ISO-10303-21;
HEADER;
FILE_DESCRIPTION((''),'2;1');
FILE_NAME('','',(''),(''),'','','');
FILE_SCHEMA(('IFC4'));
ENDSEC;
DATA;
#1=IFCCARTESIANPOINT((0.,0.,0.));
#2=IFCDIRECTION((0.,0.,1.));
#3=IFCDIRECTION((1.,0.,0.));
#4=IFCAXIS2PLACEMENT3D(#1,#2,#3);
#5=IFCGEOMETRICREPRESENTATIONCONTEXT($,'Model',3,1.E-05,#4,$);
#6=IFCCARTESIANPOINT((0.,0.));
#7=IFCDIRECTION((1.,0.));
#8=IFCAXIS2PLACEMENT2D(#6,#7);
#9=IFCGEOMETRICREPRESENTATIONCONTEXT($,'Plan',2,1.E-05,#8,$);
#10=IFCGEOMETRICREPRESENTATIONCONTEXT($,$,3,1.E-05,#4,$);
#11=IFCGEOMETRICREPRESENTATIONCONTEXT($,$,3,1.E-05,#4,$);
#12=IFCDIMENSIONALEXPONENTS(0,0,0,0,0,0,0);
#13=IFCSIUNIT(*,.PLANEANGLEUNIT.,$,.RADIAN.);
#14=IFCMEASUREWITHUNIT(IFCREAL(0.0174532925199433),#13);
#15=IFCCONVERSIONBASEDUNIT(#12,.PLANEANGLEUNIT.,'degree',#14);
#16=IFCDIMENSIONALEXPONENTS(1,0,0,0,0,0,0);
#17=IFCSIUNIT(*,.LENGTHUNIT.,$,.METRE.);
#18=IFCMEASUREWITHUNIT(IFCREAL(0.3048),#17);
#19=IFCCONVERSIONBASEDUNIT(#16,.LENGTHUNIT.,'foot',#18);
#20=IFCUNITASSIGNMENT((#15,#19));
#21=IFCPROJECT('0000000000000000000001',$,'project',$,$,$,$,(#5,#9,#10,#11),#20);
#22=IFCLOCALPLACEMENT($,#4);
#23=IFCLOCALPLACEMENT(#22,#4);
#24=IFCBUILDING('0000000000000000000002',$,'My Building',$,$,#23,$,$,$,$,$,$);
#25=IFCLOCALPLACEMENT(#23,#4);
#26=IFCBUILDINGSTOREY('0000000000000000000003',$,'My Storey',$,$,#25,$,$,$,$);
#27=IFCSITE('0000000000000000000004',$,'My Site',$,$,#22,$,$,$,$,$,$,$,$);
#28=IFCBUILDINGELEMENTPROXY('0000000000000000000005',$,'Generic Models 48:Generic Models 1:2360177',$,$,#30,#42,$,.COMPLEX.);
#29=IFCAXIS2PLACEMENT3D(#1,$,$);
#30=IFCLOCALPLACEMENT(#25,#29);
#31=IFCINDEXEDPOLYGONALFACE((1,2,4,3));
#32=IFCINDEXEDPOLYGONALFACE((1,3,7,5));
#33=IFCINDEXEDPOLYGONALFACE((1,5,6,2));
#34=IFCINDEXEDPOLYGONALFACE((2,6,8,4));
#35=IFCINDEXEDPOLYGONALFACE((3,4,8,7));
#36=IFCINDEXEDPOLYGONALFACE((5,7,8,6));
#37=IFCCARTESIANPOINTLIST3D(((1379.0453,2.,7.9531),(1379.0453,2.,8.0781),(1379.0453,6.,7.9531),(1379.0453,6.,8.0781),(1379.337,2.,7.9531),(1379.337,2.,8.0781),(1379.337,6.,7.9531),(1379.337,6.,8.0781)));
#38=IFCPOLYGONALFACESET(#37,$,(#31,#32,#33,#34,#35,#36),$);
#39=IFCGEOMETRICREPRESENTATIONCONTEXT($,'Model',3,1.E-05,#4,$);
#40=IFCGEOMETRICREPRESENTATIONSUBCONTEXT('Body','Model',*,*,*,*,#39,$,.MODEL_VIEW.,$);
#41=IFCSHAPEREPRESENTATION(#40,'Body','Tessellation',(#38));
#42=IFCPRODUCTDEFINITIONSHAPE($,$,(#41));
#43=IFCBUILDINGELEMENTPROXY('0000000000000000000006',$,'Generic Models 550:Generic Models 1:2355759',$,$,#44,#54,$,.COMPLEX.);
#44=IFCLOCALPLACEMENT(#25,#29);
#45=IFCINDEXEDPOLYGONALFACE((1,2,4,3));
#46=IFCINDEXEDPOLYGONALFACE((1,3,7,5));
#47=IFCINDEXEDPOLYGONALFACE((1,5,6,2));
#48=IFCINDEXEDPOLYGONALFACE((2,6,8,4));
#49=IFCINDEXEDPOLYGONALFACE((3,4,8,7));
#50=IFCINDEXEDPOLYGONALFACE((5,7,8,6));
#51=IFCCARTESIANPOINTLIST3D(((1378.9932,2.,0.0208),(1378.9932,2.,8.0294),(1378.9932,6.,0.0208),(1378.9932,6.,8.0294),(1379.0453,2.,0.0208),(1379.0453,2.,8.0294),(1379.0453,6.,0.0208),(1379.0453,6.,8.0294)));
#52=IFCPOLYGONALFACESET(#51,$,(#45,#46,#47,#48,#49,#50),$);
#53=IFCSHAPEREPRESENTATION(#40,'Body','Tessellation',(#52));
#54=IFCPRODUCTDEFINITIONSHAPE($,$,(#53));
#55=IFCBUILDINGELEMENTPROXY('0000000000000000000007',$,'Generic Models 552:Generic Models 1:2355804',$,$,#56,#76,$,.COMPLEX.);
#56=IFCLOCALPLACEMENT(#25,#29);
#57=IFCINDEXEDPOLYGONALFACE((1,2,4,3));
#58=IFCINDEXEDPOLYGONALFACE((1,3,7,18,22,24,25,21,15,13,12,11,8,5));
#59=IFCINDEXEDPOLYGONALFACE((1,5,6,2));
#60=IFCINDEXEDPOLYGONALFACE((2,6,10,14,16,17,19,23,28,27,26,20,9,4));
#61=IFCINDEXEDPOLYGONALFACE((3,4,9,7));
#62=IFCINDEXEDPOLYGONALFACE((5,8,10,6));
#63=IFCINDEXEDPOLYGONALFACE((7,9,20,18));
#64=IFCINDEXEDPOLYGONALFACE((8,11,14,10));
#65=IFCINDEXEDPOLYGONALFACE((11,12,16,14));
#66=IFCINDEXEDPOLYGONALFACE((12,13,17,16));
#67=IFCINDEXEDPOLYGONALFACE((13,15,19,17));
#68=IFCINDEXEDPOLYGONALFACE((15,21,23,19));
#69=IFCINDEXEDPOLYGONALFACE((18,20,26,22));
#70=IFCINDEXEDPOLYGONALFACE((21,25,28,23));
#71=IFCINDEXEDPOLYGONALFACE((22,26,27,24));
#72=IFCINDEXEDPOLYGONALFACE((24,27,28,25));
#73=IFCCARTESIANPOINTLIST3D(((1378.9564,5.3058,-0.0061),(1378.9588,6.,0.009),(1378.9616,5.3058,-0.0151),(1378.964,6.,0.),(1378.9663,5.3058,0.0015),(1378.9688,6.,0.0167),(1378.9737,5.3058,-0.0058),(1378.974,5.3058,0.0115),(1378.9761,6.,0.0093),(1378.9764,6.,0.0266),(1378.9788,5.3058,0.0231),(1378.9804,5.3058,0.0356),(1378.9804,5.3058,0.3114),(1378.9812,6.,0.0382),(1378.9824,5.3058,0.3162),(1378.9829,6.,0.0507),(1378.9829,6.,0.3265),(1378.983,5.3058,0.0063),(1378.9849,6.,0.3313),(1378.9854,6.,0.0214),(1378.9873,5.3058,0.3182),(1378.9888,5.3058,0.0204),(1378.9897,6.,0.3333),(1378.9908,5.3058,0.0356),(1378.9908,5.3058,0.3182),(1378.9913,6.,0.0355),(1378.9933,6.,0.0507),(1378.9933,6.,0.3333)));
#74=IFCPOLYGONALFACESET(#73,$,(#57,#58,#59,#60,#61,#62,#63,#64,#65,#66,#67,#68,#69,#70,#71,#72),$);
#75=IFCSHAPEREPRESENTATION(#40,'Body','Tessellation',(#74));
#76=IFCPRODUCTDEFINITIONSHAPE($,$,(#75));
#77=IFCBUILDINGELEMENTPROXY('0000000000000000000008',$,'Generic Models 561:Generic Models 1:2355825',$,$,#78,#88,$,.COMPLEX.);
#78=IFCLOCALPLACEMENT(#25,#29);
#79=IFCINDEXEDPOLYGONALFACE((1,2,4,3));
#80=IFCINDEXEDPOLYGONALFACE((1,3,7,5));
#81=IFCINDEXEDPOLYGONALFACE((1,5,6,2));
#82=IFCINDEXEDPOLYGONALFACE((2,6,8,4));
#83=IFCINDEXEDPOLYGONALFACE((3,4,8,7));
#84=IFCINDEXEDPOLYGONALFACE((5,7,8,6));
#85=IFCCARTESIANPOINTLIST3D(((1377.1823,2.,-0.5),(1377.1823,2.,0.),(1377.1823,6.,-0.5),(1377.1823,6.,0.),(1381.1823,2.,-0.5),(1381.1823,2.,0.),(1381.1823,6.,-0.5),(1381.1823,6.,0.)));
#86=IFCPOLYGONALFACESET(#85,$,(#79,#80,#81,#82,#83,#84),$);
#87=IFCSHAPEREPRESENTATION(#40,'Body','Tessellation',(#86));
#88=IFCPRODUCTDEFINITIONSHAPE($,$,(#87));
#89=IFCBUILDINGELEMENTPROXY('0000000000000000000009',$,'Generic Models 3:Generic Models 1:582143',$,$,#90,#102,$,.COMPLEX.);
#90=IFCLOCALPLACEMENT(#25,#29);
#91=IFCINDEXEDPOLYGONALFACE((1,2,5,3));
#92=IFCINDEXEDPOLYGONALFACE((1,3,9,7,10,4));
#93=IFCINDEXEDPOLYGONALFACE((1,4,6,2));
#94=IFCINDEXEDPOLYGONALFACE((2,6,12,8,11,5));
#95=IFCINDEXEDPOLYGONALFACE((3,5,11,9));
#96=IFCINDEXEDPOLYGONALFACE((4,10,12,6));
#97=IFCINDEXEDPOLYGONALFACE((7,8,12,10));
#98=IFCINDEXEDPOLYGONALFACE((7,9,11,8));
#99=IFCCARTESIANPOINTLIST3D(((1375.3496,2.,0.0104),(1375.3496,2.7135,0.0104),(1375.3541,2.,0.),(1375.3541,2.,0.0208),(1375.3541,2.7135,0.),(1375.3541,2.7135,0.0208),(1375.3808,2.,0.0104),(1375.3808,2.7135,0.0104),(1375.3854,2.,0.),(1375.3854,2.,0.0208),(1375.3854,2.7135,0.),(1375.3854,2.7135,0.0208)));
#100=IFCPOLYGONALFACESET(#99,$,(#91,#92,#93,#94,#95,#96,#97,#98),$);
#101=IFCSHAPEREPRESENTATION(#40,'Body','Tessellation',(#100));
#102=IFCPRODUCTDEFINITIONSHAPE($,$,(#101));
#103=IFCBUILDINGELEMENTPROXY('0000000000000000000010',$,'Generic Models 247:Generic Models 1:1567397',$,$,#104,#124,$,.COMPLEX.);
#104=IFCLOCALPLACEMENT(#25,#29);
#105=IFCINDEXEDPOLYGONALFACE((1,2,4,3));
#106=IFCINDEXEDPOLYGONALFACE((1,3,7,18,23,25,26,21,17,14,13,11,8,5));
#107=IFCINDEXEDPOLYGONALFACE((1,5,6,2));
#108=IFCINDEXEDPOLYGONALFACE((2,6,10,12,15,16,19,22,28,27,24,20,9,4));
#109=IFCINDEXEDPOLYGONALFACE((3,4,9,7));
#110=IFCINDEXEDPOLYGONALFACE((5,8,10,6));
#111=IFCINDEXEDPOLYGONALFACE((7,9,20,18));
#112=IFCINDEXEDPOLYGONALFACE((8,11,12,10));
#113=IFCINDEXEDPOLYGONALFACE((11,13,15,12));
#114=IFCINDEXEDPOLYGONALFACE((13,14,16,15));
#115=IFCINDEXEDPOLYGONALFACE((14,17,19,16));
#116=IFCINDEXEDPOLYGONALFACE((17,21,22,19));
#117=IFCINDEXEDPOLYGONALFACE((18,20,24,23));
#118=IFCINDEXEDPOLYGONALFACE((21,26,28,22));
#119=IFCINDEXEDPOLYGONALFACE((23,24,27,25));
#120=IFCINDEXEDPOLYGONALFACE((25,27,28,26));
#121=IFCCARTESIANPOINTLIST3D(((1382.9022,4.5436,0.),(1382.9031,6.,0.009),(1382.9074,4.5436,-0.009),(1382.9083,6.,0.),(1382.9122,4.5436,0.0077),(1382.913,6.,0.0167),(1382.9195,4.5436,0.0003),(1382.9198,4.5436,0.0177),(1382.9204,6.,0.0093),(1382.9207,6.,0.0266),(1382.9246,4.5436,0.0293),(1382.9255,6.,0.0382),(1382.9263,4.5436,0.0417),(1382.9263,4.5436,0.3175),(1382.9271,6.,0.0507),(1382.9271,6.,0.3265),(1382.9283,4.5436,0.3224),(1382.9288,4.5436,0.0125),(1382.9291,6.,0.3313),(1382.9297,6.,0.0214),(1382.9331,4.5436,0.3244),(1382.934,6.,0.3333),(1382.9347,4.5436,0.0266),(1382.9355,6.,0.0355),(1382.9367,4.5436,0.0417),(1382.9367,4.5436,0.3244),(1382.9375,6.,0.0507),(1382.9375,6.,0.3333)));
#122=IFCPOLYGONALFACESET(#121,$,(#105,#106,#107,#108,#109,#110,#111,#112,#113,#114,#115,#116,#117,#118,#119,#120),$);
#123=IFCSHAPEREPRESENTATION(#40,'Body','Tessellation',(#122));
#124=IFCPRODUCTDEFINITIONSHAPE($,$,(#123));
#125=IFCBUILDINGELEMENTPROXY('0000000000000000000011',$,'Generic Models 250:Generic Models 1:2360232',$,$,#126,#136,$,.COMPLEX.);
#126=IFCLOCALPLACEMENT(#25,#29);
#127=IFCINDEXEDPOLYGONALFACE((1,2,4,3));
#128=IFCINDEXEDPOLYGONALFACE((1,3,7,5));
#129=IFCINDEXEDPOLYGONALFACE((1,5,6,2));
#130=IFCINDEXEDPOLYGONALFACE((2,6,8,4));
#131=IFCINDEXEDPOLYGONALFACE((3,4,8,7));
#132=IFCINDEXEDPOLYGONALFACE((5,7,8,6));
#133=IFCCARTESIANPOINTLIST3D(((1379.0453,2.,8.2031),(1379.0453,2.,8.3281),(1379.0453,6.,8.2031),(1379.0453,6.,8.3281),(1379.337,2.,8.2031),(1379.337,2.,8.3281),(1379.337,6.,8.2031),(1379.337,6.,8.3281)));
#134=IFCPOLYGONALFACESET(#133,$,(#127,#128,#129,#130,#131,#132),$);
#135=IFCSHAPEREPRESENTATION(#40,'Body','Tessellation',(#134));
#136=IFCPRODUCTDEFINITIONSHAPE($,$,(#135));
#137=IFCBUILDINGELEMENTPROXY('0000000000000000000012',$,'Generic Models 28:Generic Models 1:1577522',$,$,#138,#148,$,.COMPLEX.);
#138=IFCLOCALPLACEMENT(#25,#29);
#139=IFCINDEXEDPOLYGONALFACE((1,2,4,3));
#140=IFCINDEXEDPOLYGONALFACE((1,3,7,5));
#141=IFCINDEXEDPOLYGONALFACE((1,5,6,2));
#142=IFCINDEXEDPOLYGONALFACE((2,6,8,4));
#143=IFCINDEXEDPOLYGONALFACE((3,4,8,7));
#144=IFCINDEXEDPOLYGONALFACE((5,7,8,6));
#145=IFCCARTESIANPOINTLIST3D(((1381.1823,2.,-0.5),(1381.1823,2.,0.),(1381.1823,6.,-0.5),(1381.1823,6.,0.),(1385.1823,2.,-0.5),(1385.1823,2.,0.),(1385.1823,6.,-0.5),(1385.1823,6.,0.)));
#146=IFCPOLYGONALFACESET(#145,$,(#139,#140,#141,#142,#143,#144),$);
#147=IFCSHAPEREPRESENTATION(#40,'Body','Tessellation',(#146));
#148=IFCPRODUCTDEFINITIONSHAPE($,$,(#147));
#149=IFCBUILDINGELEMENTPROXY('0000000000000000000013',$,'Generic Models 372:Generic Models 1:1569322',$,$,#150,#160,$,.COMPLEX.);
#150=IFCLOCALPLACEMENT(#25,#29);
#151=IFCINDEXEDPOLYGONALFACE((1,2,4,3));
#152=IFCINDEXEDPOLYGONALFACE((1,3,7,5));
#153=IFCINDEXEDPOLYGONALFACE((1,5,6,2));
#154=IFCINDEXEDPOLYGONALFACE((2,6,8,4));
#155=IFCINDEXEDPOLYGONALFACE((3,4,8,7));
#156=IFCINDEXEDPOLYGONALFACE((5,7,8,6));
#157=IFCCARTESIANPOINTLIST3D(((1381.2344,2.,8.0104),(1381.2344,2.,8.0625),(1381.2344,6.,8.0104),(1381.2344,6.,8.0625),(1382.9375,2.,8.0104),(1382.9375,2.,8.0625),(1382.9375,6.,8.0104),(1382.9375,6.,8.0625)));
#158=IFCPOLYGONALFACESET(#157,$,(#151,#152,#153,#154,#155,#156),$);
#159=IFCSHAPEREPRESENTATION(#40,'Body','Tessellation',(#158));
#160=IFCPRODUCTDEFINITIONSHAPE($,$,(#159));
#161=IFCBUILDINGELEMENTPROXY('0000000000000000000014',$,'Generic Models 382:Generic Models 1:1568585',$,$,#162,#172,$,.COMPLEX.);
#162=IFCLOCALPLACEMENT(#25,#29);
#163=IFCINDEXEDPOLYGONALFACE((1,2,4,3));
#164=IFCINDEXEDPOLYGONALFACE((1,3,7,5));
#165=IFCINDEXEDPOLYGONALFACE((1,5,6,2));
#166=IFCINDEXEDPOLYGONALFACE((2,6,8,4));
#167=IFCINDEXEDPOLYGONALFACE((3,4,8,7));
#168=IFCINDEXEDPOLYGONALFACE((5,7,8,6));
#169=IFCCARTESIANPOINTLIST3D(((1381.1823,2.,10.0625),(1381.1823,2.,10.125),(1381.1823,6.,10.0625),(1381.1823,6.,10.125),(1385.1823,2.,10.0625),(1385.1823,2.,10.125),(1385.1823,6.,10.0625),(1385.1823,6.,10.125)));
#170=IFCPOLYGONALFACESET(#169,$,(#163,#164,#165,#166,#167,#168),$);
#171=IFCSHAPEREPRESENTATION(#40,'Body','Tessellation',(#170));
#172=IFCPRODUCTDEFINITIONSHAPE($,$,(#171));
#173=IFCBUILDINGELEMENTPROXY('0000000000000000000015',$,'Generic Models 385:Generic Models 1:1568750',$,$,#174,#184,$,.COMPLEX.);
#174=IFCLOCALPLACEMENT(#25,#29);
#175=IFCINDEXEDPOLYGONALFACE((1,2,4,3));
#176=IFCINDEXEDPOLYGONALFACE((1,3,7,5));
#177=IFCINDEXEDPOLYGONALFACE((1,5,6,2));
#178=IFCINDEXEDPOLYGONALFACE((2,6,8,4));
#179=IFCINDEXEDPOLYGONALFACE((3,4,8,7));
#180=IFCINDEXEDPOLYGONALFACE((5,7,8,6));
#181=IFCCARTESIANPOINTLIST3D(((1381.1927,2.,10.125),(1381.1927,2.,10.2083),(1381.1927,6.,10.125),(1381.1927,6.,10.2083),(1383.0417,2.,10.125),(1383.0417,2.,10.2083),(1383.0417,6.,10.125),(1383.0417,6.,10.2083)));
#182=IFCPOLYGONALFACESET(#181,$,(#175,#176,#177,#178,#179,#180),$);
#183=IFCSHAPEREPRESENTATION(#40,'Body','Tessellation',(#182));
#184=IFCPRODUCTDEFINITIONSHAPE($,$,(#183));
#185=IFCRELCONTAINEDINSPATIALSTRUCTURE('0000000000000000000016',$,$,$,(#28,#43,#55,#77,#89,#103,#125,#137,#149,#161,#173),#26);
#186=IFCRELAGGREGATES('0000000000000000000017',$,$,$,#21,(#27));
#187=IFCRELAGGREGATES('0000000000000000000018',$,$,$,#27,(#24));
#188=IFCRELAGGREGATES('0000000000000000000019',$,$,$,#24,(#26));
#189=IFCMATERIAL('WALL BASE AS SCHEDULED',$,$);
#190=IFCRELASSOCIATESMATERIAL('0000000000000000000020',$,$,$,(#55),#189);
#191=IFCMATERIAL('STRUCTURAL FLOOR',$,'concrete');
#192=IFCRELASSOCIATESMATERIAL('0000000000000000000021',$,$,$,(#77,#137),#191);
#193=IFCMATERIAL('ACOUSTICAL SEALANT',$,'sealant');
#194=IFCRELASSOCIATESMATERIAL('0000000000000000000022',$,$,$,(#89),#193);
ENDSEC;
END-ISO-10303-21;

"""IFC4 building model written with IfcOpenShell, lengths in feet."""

from ifc_helpers import new_model, entity, si_unit, converted_unit, frame, origin_with_axes, origin_2d_with_axis, place, context, subcontext, project, spatial, polyline, outline, extrude, material, element, save


model = new_model("IFC4")

# Units and contexts
model_context_1 = context("Model", 3, precision=1e-05, world=origin_with_axes())
plan_context = context("Plan", 2, precision=1e-05, world=origin_2d_with_axis())
model_context_2 = context("Model", 3, precision=1e-05, world=origin_with_axes())
context_of_model_1 = context(None, 3, precision=1e-05, world=origin_with_axes())
context_of_model_2 = context(None, 3, precision=1e-05, world=origin_with_axes())
body_context = subcontext(model_context_2, "Body", "Model", "MODEL_VIEW")
ifc_project = project(units=[converted_unit("PLANEANGLEUNIT", "degree", entity("IfcReal", 0.0174532925199433), si_unit("PLANEANGLEUNIT", "RADIAN"), dimensions=[0, 0, 0, 0, 0, 0, 0]), converted_unit("LENGTHUNIT", "foot", entity("IfcReal", 0.3048), si_unit("LENGTHUNIT", "METRE"), dimensions=[1, 0, 0, 0, 0, 0, 0])], contexts=[model_context_1, plan_context, context_of_model_1, context_of_model_2])

# Site, building, storey
site_placement = place(None, origin_with_axes())
site = spatial("IfcSite", under=ifc_project, at=site_placement, Name="My Site")
building_placement = place(site_placement, origin_with_axes())
building = spatial("IfcBuilding", under=site, at=building_placement, Name="My Building")
storey_placement = place(building_placement, origin_with_axes())
storey = spatial("IfcBuildingStorey", under=building, at=storey_placement, Name="My Storey")

# Building element proxies
proxy_1_placement = place(storey_placement, frame((1379.0453, 6.0, 7.9531), z_axis=(0.0, -1.0, 0.0), x_axis=(0.0, 0.0, 1.0)))
element("IfcBuildingElementProxy", 1, at=proxy_1_placement, inside=storey, Name="Generic Models 48:Generic Models 1:2360177", PredefinedType="COMPLEX", context=body_context, shape_type="SweptSolid", body=[
    extrude(outline(polyline([(-0.1458, -0.0625), (0.1458, -0.0625), (0.1458, 0.0625), (-0.1458, 0.0625), (-0.1458, -0.0625)])), frame((0.0625, -0.1458, 0.0), z_axis=(0.0, 0.0, -1.0), x_axis=(0.0, 1.0, 0.0)), (0.0, 0.0, -1.0), 4.0),
])
proxy_2_placement = place(storey_placement, frame((1378.9932, 6.0, 0.0208), z_axis=(0.0, -1.0, 0.0), x_axis=(0.0, 0.0, 1.0)))
element("IfcBuildingElementProxy", 2, at=proxy_2_placement, inside=storey, Name="Generic Models 550:Generic Models 1:2355759", PredefinedType="COMPLEX", context=body_context, shape_type="SweptSolid", body=[
    extrude(outline(polyline([(-4.0043, -0.026), (4.0043, -0.026), (4.0043, 0.026), (-4.0043, 0.026), (-4.0043, -0.026)])), frame((4.0043, -0.026, 0.0), z_axis=(0.0, 0.0, -1.0), x_axis=(1.0, 0.0, 0.0)), (0.0, 0.0, -1.0), 4.0),
])
ifc_material_1 = material(Name="WALL BASE AS SCHEDULED")
proxy_3_placement = place(storey_placement, frame((1378.9588, 6.0, 0.0), z_axis=(0.0, -1.0, 0.0), x_axis=(0.0, 0.0, 1.0)))
element("IfcBuildingElementProxy", 3, at=proxy_3_placement, inside=storey, material=ifc_material_1, Name="Generic Models 552:Generic Models 1:2355804", PredefinedType="COMPLEX", context=body_context, shape_type="SweptSolid", body=[
    extrude(outline(polyline([(0.2205, 0.0), (0.2206, 0.0036), (-0.0618, 0.0152), (-0.077, 0.0138), (-0.0914, 0.0086), (-0.1038, -0.0002), (-0.1136, -0.012), (-0.1048, -0.0175), (-0.0968, -0.0079), (-0.0865, -0.0007), (-0.0747, 0.0037), (-0.0622, 0.0048), (0.2133, -0.0066), (0.2183, -0.0048), (0.2205, 0.0)])), frame((0.113, -0.0218, 0.0), z_axis=(0.0, 0.0, -1.0), x_axis=(0.999153, -0.041137, 0.0)), (-0.02192, -0.002617, -0.999756), 0.6943),
])
ifc_material_2 = material(Name="STRUCTURAL FLOOR", Category="concrete")
proxy_4_placement = place(storey_placement, frame((1377.1823, 6.0, -0.5), z_axis=(0.0, -1.0, 0.0), x_axis=(0.0, 0.0, 1.0)))
element("IfcBuildingElementProxy", 4, at=proxy_4_placement, inside=storey, material=ifc_material_2, Name="Generic Models 561:Generic Models 1:2355825", PredefinedType="COMPLEX", context=body_context, shape_type="SweptSolid", body=[
    extrude(outline(polyline([(-0.25, -2.0), (0.25, -2.0), (0.25, 2.0), (-0.25, 2.0), (-0.25, -2.0)])), frame((0.25, -2.0, 0.0), z_axis=(0.0, 0.0, -1.0), x_axis=(1.0, 0.0, 0.0)), (0.0, 0.0, -1.0), 4.0),
])
ifc_material_3 = material(Name="ACOUSTICAL SEALANT", Category="sealant")
proxy_5_placement = place(storey_placement, frame((1375.3497, 6.0, 0.0), z_axis=(0.0, -1.0, 0.0), x_axis=(0.0, 0.0, -1.0)))
element("IfcBuildingElementProxy", 5, at=proxy_5_placement, inside=storey, material=ifc_material_3, Name="Generic Models 3:Generic Models 1:582143", PredefinedType="COMPLEX", context=body_context, shape_type="SweptSolid", body=[
    extrude(outline(polyline([(0.0187, 0.0), (0.0141, 0.0104), (-0.0172, 0.0104), (-0.0126, 0.0), (-0.0172, -0.0104), (0.0141, -0.0104), (0.0187, 0.0)])), frame((-0.0104, 0.0186, 3.2865), z_axis=(0.0, 0.0, -1.0), x_axis=(0.0, -1.0, 0.0)), (0.0, 0.0, -1.0), 0.7135),
])
proxy_6_placement = place(storey_placement, frame((1382.9031, 6.0, 0.0), z_axis=(0.0, -1.0, 0.0), x_axis=(0.0, 0.0, 1.0)))
element("IfcBuildingElementProxy", 6, at=proxy_6_placement, inside=storey, Name="Generic Models 247:Generic Models 1:1567397", PredefinedType="COMPLEX", context=body_context, shape_type="SweptSolid", body=[
    extrude(outline(polyline([(-0.0624, 0.0022), (0.2134, 0.0022), (0.2183, 0.0042), (0.2203, 0.0091), (0.2203, 0.0126), (-0.0624, 0.0126), (-0.0775, 0.0106), (-0.0916, 0.0048), (-0.1037, -0.0045), (-0.113, -0.0166), (-0.104, -0.0218), (-0.0964, -0.0119), (-0.0864, -0.0042), (-0.0748, 0.0006), (-0.0624, 0.0022)])), frame((0.113, -0.0218, 0.0), z_axis=(0.0, 0.0, -1.0), x_axis=(1.0, 0.0, 0.0)), (-0.006161, -0.00058, -0.999981), 1.4564),
])
proxy_7_placement = place(storey_placement, frame((1379.0453, 6.0, 8.2031), z_axis=(0.0, -1.0, 0.0), x_axis=(0.0, 0.0, 1.0)))
element("IfcBuildingElementProxy", 7, at=proxy_7_placement, inside=storey, Name="Generic Models 250:Generic Models 1:2360232", PredefinedType="COMPLEX", context=body_context, shape_type="SweptSolid", body=[
    extrude(outline(polyline([(-0.0625, -0.1458), (0.0625, -0.1458), (0.0625, 0.1458), (-0.0625, 0.1458), (-0.0625, -0.1458)])), frame((0.0625, -0.1458, 0.0), z_axis=(0.0, 0.0, -1.0), x_axis=(-1.0, 0.0, 0.0)), (0.0, 0.0, -1.0), 4.0),
])
proxy_8_placement = place(storey_placement, frame((1381.1823, 6.0, -0.5), z_axis=(0.0, -1.0, 0.0), x_axis=(0.0, 0.0, 1.0)))
element("IfcBuildingElementProxy", 8, at=proxy_8_placement, inside=storey, material=ifc_material_2, Name="Generic Models 28:Generic Models 1:1577522", PredefinedType="COMPLEX", context=body_context, shape_type="SweptSolid", body=[
    extrude(outline(polyline([(-0.25, -2.0), (0.25, -2.0), (0.25, 2.0), (-0.25, 2.0), (-0.25, -2.0)])), frame((0.25, -2.0, 0.0), z_axis=(0.0, 0.0, -1.0), x_axis=(1.0, 0.0, 0.0)), (0.0, 0.0, -1.0), 4.0),
])
proxy_9_placement = place(storey_placement, frame((1381.2344, 6.0, 8.0104), z_axis=(0.0, -1.0, 0.0), x_axis=(0.0, 0.0, 1.0)))
element("IfcBuildingElementProxy", 9, at=proxy_9_placement, inside=storey, Name="Generic Models 372:Generic Models 1:1569322", PredefinedType="COMPLEX", context=body_context, shape_type="SweptSolid", body=[
    extrude(outline(polyline([(-0.026, -0.8516), (0.026, -0.8516), (0.026, 0.8516), (-0.026, 0.8516), (-0.026, -0.8516)])), frame((0.026, -0.8516, 0.0), z_axis=(0.0, 0.0, -1.0), x_axis=(1.0, 0.0, 0.0)), (0.0, 0.0, -1.0), 4.0),
])
proxy_10_placement = place(storey_placement, frame((1381.1823, 6.0, 10.0625), z_axis=(0.0, -1.0, 0.0), x_axis=(0.0, 0.0, 1.0)))
element("IfcBuildingElementProxy", 10, at=proxy_10_placement, inside=storey, Name="Generic Models 382:Generic Models 1:1568585", PredefinedType="COMPLEX", context=body_context, shape_type="SweptSolid", body=[
    extrude(outline(polyline([(-0.0313, -2.0), (0.0312, -2.0), (0.0313, 2.0), (-0.0312, 2.0), (-0.0313, -2.0)])), frame((0.0313, -2.0, 0.0), z_axis=(0.0, 0.0, -1.0), x_axis=(-1.0, 0.0, 0.0)), (0.0, 0.0, -1.0), 4.0),
])
proxy_11_placement = place(storey_placement, frame((1381.1927, 6.0, 10.125), z_axis=(0.0, -1.0, 0.0), x_axis=(0.0, 0.0, 1.0)))
element("IfcBuildingElementProxy", 11, at=proxy_11_placement, inside=storey, Name="Generic Models 385:Generic Models 1:1568750", PredefinedType="COMPLEX", context=body_context, shape_type="SweptSolid", body=[
    extrude(outline(polyline([(-0.0417, -0.9245), (0.0417, -0.9245), (0.0417, 0.9245), (-0.0417, 0.9245), (-0.0417, -0.9245)])), frame((0.0417, -0.9245, 0.0), z_axis=(0.0, 0.0, -1.0), x_axis=(1.0, 0.0, 0.0)), (0.0, 0.0, -1.0), 4.0),
])

save(model, "model.ifc")
